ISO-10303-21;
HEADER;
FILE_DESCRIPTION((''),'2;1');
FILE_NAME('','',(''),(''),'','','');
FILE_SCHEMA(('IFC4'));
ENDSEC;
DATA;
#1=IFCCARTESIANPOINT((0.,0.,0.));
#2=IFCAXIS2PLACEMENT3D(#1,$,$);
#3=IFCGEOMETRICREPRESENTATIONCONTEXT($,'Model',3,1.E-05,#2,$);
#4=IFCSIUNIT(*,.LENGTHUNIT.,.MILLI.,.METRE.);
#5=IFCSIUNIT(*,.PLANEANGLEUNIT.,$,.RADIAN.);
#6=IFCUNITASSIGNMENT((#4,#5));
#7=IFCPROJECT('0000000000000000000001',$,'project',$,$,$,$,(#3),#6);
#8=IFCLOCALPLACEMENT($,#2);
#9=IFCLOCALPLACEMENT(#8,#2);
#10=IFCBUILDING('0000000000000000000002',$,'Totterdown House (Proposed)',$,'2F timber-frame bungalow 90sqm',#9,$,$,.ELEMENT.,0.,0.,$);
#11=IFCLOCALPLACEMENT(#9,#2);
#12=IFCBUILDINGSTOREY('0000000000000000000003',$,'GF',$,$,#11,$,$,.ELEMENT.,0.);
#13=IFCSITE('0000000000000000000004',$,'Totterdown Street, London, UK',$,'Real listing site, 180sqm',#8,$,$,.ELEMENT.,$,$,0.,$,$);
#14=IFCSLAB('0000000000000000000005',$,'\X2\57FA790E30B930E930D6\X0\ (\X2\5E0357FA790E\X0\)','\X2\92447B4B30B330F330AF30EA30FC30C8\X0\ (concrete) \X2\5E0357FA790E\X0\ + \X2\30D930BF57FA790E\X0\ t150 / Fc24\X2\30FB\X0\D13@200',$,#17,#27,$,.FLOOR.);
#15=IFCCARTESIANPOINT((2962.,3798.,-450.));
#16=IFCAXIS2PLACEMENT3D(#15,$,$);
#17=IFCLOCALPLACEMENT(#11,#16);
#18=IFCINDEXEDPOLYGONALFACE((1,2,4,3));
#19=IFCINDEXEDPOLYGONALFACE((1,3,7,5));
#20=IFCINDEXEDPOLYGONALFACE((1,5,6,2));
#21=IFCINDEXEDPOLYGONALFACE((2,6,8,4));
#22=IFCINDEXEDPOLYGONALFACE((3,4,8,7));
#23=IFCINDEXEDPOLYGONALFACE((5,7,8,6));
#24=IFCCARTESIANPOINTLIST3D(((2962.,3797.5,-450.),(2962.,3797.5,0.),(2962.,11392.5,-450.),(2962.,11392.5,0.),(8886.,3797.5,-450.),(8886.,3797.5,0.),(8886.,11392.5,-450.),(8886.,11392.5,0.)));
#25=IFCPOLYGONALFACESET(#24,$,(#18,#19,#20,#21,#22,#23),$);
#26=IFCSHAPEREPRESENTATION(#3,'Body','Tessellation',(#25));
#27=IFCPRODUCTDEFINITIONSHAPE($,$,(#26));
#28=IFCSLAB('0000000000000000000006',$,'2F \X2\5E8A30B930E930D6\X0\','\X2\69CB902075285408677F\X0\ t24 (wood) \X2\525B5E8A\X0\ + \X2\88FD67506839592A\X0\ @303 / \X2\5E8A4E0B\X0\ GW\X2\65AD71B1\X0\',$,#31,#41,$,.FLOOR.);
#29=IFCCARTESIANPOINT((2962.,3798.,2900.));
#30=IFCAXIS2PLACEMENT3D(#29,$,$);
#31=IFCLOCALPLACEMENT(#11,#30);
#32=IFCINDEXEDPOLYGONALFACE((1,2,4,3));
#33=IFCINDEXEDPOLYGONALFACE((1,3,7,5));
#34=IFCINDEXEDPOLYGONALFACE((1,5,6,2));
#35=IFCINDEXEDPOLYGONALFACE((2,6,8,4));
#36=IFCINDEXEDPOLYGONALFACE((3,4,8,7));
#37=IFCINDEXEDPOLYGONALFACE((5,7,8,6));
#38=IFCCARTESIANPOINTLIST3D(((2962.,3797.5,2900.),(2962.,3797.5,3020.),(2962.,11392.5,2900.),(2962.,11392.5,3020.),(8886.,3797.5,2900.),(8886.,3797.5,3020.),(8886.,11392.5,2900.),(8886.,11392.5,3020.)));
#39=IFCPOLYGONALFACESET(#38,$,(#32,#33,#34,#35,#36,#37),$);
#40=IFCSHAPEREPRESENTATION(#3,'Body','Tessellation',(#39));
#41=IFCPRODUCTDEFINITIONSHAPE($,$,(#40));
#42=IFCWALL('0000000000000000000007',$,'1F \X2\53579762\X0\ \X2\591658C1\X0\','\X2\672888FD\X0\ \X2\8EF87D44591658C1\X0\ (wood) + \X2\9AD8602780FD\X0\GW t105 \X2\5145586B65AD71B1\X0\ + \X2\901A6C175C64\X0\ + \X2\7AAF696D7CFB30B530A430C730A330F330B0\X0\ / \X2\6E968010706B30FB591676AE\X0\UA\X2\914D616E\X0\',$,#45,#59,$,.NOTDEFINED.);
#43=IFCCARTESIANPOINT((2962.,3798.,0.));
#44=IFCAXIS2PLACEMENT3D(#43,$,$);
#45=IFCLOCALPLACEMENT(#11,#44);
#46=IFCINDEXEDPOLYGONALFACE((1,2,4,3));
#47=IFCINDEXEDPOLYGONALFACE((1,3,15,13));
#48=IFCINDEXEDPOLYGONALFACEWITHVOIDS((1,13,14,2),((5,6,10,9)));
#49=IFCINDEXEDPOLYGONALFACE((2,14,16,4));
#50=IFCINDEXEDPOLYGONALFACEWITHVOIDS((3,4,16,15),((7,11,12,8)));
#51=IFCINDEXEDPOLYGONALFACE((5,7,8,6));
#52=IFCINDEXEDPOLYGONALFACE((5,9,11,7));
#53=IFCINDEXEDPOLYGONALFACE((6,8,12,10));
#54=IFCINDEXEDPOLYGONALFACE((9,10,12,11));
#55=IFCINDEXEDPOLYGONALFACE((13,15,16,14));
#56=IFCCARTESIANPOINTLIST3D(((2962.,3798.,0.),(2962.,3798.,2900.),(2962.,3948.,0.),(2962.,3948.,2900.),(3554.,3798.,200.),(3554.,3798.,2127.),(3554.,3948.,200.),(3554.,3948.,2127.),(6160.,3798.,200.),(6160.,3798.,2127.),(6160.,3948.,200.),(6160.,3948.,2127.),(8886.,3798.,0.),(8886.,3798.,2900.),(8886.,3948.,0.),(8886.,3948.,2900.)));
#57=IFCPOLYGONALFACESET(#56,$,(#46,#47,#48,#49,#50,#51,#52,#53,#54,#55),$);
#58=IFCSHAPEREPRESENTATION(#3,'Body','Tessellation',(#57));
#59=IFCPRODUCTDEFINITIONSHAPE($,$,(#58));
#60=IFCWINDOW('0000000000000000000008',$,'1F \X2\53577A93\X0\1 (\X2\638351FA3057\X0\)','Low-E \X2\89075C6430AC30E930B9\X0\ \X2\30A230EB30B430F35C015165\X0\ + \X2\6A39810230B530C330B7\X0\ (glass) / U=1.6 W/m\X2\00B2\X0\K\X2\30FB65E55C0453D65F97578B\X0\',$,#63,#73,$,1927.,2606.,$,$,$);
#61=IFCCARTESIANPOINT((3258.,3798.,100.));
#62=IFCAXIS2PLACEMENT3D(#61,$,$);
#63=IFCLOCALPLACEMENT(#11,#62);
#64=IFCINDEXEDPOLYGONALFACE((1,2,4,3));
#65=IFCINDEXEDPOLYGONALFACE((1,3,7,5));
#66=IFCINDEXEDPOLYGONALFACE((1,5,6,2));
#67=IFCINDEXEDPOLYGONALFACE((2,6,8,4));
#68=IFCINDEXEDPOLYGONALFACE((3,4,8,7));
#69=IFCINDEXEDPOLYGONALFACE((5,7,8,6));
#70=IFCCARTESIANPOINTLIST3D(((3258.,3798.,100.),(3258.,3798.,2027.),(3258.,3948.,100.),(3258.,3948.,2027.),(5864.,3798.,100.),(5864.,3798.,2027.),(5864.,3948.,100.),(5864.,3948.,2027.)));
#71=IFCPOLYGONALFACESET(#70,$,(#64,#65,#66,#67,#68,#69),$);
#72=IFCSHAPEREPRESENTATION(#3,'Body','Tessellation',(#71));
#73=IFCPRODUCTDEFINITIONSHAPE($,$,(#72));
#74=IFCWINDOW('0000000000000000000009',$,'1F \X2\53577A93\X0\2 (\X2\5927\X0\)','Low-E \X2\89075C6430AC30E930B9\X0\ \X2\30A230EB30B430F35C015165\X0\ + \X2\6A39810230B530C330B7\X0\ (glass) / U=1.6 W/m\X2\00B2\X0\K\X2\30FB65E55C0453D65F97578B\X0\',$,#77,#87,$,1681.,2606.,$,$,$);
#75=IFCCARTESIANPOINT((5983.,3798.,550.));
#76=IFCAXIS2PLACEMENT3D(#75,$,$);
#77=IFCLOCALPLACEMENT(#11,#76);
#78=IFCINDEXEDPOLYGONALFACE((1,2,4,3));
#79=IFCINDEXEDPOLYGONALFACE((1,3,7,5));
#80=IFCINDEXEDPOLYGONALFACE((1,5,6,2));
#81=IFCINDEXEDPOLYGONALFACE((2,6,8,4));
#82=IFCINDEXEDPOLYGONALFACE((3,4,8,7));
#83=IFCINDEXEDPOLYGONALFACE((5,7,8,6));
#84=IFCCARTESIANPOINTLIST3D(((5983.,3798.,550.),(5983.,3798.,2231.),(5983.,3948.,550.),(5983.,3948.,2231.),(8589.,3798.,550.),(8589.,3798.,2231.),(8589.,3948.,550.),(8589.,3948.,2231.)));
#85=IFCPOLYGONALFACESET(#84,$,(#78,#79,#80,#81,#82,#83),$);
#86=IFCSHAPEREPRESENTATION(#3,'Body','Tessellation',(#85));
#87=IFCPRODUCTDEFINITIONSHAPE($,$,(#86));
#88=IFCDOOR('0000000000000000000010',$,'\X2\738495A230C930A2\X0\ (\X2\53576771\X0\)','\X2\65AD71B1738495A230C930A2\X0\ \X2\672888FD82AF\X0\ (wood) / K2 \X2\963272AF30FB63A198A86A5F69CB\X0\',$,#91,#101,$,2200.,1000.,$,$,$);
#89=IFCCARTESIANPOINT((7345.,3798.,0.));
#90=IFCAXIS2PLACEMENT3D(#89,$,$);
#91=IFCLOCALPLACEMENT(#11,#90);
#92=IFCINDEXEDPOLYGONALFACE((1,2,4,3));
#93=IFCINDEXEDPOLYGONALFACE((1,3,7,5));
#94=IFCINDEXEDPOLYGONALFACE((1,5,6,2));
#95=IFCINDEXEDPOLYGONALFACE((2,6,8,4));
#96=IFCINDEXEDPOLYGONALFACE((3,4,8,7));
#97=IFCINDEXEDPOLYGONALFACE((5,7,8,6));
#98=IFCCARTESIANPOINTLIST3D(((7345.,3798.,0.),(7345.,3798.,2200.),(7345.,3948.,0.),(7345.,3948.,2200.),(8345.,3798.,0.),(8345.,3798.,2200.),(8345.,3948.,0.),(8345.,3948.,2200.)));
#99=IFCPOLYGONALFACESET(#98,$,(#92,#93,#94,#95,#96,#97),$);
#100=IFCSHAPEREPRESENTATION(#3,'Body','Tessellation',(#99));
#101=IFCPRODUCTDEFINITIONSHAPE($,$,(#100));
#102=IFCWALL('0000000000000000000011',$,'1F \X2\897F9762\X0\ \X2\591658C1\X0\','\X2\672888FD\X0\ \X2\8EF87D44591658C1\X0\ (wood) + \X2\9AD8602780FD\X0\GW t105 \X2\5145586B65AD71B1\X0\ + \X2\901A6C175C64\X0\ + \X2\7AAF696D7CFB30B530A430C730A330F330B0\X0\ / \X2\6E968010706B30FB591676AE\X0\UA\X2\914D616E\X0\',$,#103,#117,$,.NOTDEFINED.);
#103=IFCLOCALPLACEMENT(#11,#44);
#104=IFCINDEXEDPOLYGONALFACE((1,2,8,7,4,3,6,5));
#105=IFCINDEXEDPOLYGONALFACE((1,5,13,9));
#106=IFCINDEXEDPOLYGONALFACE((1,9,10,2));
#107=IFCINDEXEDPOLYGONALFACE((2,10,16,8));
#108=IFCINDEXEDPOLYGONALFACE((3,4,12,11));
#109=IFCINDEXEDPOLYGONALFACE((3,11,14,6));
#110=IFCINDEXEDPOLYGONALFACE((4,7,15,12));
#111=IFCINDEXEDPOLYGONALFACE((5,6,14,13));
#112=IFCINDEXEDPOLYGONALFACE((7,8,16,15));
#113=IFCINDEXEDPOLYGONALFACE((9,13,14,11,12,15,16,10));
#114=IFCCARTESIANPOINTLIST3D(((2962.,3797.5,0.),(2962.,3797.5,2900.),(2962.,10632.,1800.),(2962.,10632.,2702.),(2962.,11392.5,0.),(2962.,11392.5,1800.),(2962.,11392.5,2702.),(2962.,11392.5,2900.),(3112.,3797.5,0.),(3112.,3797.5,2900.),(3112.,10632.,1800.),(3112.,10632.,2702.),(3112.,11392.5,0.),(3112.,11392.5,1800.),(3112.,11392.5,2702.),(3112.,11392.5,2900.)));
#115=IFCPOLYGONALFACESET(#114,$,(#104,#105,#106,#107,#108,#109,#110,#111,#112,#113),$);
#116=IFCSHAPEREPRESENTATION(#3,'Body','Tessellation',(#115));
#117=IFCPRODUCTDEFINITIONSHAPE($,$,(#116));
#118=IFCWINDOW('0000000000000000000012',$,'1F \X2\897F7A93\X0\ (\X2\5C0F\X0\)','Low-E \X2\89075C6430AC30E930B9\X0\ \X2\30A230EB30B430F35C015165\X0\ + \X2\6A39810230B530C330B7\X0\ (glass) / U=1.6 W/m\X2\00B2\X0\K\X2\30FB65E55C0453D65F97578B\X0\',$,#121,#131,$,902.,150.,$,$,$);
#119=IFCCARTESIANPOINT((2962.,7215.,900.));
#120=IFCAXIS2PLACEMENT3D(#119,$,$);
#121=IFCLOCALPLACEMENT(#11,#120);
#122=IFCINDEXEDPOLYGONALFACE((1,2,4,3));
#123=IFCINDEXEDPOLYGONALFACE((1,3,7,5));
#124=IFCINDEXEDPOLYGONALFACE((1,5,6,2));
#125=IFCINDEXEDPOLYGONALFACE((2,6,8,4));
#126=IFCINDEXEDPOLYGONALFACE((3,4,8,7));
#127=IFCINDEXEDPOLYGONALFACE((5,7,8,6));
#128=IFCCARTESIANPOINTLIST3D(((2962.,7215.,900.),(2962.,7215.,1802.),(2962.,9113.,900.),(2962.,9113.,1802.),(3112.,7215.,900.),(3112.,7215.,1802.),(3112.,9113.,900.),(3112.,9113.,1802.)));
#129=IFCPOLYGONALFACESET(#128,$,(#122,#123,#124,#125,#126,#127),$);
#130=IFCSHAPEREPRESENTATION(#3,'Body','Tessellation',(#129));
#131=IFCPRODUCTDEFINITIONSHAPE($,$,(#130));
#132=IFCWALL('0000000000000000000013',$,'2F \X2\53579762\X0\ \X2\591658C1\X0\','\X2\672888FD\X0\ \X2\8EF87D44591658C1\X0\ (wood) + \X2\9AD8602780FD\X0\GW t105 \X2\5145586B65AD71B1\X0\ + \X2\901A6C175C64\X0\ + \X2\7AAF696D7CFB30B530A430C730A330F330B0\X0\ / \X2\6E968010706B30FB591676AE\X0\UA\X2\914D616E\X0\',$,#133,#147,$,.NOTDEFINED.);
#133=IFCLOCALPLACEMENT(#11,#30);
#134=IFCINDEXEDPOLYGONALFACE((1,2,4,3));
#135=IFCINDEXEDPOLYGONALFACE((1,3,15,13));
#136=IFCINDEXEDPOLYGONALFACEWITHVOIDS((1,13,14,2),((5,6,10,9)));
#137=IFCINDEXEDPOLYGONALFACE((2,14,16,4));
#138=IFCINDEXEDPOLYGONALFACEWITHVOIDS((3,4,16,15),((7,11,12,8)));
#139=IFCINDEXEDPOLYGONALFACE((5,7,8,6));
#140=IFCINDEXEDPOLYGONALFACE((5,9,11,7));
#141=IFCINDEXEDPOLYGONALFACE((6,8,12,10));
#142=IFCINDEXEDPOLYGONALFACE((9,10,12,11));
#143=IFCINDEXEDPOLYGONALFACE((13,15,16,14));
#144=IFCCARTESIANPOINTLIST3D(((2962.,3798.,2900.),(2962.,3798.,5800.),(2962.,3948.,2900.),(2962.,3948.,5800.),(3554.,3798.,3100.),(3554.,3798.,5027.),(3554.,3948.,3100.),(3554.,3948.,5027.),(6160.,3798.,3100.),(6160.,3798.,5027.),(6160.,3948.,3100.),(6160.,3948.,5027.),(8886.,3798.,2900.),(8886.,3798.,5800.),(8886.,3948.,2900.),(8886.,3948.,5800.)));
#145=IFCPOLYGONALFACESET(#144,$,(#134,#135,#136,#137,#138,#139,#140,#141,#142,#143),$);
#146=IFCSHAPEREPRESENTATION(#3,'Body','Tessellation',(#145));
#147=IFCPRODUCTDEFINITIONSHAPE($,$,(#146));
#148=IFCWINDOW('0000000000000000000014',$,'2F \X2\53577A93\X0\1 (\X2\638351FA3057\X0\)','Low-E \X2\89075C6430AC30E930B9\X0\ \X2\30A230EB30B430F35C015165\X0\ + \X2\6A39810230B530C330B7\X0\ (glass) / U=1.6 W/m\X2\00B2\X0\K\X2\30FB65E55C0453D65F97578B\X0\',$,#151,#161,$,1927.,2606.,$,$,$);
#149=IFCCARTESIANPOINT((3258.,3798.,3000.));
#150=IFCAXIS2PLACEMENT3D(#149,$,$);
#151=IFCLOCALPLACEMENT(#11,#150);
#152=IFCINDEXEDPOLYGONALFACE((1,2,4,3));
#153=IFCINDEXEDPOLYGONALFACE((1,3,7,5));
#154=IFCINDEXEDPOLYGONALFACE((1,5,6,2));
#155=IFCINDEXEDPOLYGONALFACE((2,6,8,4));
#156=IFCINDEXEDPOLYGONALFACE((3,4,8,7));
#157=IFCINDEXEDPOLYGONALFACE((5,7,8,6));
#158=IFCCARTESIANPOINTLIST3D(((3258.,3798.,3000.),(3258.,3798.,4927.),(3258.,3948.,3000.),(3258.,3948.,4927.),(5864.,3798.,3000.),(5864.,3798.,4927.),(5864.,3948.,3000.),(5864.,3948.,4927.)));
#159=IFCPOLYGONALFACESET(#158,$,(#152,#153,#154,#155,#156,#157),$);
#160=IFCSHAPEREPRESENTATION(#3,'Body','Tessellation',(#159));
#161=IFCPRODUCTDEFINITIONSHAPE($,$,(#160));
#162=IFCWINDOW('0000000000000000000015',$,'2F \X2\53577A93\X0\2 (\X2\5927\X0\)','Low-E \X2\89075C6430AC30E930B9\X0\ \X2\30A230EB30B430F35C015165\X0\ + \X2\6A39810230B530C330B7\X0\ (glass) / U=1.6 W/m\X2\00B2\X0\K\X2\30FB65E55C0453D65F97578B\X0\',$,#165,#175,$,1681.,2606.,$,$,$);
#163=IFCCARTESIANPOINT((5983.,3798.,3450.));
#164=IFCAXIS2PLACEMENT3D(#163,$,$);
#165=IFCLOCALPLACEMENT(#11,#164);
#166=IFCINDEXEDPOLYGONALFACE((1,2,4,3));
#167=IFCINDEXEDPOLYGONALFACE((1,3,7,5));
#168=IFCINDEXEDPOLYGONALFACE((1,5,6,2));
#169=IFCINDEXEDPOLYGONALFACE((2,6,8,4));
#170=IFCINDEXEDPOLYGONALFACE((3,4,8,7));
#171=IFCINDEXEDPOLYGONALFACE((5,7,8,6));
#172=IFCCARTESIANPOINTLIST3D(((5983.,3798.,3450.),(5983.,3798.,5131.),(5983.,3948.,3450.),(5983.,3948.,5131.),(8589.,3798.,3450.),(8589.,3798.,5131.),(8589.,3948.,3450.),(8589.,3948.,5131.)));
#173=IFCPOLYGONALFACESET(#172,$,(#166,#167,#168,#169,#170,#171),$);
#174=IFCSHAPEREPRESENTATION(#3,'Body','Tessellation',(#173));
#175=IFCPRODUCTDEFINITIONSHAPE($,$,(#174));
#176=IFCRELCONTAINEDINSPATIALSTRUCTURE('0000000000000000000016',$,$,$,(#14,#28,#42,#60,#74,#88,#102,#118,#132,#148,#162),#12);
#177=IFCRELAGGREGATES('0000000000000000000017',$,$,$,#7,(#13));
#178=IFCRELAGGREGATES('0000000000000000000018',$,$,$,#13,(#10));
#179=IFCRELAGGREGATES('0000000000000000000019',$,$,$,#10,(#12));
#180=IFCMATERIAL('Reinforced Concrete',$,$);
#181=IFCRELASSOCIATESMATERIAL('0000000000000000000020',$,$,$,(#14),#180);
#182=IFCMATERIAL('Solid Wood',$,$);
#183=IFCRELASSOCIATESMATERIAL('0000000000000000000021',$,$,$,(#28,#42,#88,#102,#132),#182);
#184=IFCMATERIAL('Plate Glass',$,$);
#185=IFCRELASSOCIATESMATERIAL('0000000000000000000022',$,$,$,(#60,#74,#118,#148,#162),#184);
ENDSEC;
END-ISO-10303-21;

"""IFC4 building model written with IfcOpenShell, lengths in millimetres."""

from ifc_helpers import new_model, si_unit, frame, frame_2d, origin, place, context, project, spatial, rectangle, extrude, material, element, fill, save


model = new_model("IFC4")

# Units and contexts
model_context = context("Model", 3, precision=1e-05, world=origin())
ifc_project = project(units=[si_unit("LENGTHUNIT", "METRE", prefix="MILLI"), si_unit("PLANEANGLEUNIT", "RADIAN")], contexts=[model_context])

# Site, building, storey
site_placement = place(None, origin())
site = spatial("IfcSite", under=ifc_project, at=site_placement, Name="Totterdown Street, London, UK", ObjectType="Real listing site, 180sqm", CompositionType="ELEMENT", RefElevation=0.0)
building_placement = place(site_placement, origin())
building = spatial("IfcBuilding", under=site, at=building_placement, Name="Totterdown House (Proposed)", ObjectType="2F timber-frame bungalow 90sqm", CompositionType="ELEMENT", ElevationOfRefHeight=0.0, ElevationOfTerrain=0.0)
storey_placement = place(building_placement, origin())
storey = spatial("IfcBuildingStorey", under=building, at=storey_placement, Name="GF", CompositionType="ELEMENT", Elevation=0.0)

# Slabs
ifc_material_1 = material(Name="Reinforced Concrete")
slab_1_placement = place(storey_placement, frame((2962.0, 3798.0, -450.0)))
element("IfcSlab", 1, at=slab_1_placement, inside=storey, material=ifc_material_1, Name="基礎スラブ (布基礎)", Description="鉄筋コンクリート (concrete) 布基礎 + ベタ基礎 t150 / Fc24・D13@200", PredefinedType="FLOOR", context=model_context, shape_type="SweptSolid", body=[
    extrude(rectangle(XDim=5924.0, YDim=7595.0, at=frame_2d((2962.0, 3797.0))), frame((2962.0, 3798.0, -450.0)), (0.0, 0.0, 1.0), 450.0),
])
ifc_material_2 = material(Name="Solid Wood")
slab_2_placement = place(storey_placement, frame((2962.0, 3798.0, 2900.0)))
element("IfcSlab", 2, at=slab_2_placement, inside=storey, material=ifc_material_2, Name="2F 床スラブ", Description="構造用合板 t24 (wood) 剛床 + 製材根太 @303 / 床下 GW断熱", PredefinedType="FLOOR", context=model_context, shape_type="SweptSolid", body=[
    extrude(rectangle(XDim=5924.0, YDim=7595.0, at=frame_2d((2962.0, 3797.0))), frame((2962.0, 3798.0, 2900.0)), (0.0, 0.0, 1.0), 120.0),
])

# Wall, openings, windows, door
wall_1_placement = place(storey_placement, frame((2962.0, 3798.0, 0.0)))
wall_1 = element("IfcWall", 3, at=wall_1_placement, inside=storey, material=ifc_material_2, Name="1F 南面 外壁", Description="木製 軸組外壁 (wood) + 高性能GW t105 充填断熱 + 通気層 + 窯業系サイディング / 準耐火・外皮UA配慮", PredefinedType="NOTDEFINED", context=model_context, shape_type="SweptSolid", body=[
    extrude(rectangle(XDim=5924.0, YDim=150.0, at=frame_2d((2962.0, 75.0))), frame((2962.0, 3798.0, 0.0)), (0.0, 0.0, 1.0), 2900.0),
])
opening_1_placement = place(storey_placement, frame((3258.0, 3798.0, 100.0)))
opening_1 = element("IfcOpeningElement", 4, at=opening_1_placement, cuts=wall_1, PredefinedType="NOTDEFINED", context=model_context, shape_type="SweptSolid", body=[
    extrude(rectangle(XDim=2606.0, YDim=150.0, at=frame_2d((1303.0, 75.0))), frame((3258.0, 3798.0, 100.0)), (0.0, 0.0, 1.0), 1927.0),
])
opening_2_placement = place(storey_placement, frame((5983.0, 3798.0, 550.0)))
opening_2 = element("IfcOpeningElement", 5, at=opening_2_placement, cuts=wall_1, PredefinedType="NOTDEFINED", context=model_context, shape_type="SweptSolid", body=[
    extrude(rectangle(XDim=2606.0, YDim=150.0, at=frame_2d((1303.0, 75.0))), frame((5983.0, 3798.0, 550.0)), (0.0, 0.0, 1.0), 1681.0),
])
opening_3_placement = place(storey_placement, frame((7345.0, 3798.0, 0.0)))
opening_3 = element("IfcOpeningElement", 6, at=opening_3_placement, cuts=wall_1, PredefinedType="NOTDEFINED", context=model_context, shape_type="SweptSolid", body=[
    extrude(rectangle(XDim=1000.0, YDim=150.0, at=frame_2d((500.0, 75.0))), frame((7345.0, 3798.0, 0.0)), (0.0, 0.0, 1.0), 2200.0),
])
ifc_material_3 = material(Name="Plate Glass")
window_1_placement = place(storey_placement, frame((3258.0, 3798.0, 100.0)))
window_1 = element("IfcWindow", 7, at=window_1_placement, inside=storey, material=ifc_material_3, Name="1F 南窓1 (掃出し)", Description="Low-E 複層ガラス アルゴン封入 + 樹脂サッシ (glass) / U=1.6 W/m²K・日射取得型", OverallHeight=1927.0, OverallWidth=2606.0, context=model_context, shape_type="SweptSolid", body=[
    extrude(rectangle(XDim=2606.0, YDim=150.0, at=frame_2d((1303.0, 75.0))), frame((3258.0, 3798.0, 100.0)), (0.0, 0.0, 1.0), 1927.0),
])
fill(opening_1, window_1)
window_2_placement = place(storey_placement, frame((5983.0, 3798.0, 550.0)))
window_2 = element("IfcWindow", 8, at=window_2_placement, inside=storey, material=ifc_material_3, Name="1F 南窓2 (大)", Description="Low-E 複層ガラス アルゴン封入 + 樹脂サッシ (glass) / U=1.6 W/m²K・日射取得型", OverallHeight=1681.0, OverallWidth=2606.0, context=model_context, shape_type="SweptSolid", body=[
    extrude(rectangle(XDim=2606.0, YDim=150.0, at=frame_2d((1303.0, 75.0))), frame((5983.0, 3798.0, 550.0)), (0.0, 0.0, 1.0), 1681.0),
])
fill(opening_2, window_2)
door_placement = place(storey_placement, frame((7345.0, 3798.0, 0.0)))
door = element("IfcDoor", 9, at=door_placement, inside=storey, material=ifc_material_2, Name="玄関ドア (南東)", Description="断熱玄関ドア 木製芯 (wood) / K2 防犯・採風機構", OverallHeight=2200.0, OverallWidth=1000.0, context=model_context, shape_type="SweptSolid", body=[
    extrude(rectangle(XDim=1000.0, YDim=150.0, at=frame_2d((500.0, 75.0))), frame((7345.0, 3798.0, 0.0)), (0.0, 0.0, 1.0), 2200.0),
])
fill(opening_3, door)

# Wall, opening, window
wall_2_placement = place(storey_placement, frame((2962.0, 3798.0, 0.0)))
wall_2 = element("IfcWall", 10, at=wall_2_placement, inside=storey, material=ifc_material_2, Name="1F 西面 外壁", Description="木製 軸組外壁 (wood) + 高性能GW t105 充填断熱 + 通気層 + 窯業系サイディング / 準耐火・外皮UA配慮", PredefinedType="NOTDEFINED", context=model_context, shape_type="SweptSolid", body=[
    extrude(rectangle(XDim=150.0, YDim=7595.0, at=frame_2d((75.0, 3797.0))), frame((2962.0, 3798.0, 0.0)), (0.0, 0.0, 1.0), 2900.0),
])
opening_4_placement = place(storey_placement, frame((2962.0, 7215.0, 900.0)))
opening_4 = element("IfcOpeningElement", 11, at=opening_4_placement, cuts=wall_2, PredefinedType="NOTDEFINED", context=model_context, shape_type="SweptSolid", body=[
    extrude(rectangle(XDim=150.0, YDim=1898.0, at=frame_2d((75.0, 949.0))), frame((2962.0, 7215.0, 900.0)), (0.0, 0.0, 1.0), 902.0),
])
window_3_placement = place(storey_placement, frame((2962.0, 7215.0, 900.0)))
window_3 = element("IfcWindow", 12, at=window_3_placement, inside=storey, material=ifc_material_3, Name="1F 西窓 (小)", Description="Low-E 複層ガラス アルゴン封入 + 樹脂サッシ (glass) / U=1.6 W/m²K・日射取得型", OverallHeight=902.0, OverallWidth=150.0, context=model_context, shape_type="SweptSolid", body=[
    extrude(rectangle(XDim=150.0, YDim=1898.0, at=frame_2d((75.0, 949.0))), frame((2962.0, 7215.0, 900.0)), (0.0, 0.0, 1.0), 902.0),
])
fill(opening_4, window_3)

# Wall, openings, windows
wall_3_placement = place(storey_placement, frame((2962.0, 3798.0, 2900.0)))
wall_3 = element("IfcWall", 13, at=wall_3_placement, inside=storey, material=ifc_material_2, Name="2F 南面 外壁", Description="木製 軸組外壁 (wood) + 高性能GW t105 充填断熱 + 通気層 + 窯業系サイディング / 準耐火・外皮UA配慮", PredefinedType="NOTDEFINED", context=model_context, shape_type="SweptSolid", body=[
    extrude(rectangle(XDim=5924.0, YDim=150.0, at=frame_2d((2962.0, 75.0))), frame((2962.0, 3798.0, 2900.0)), (0.0, 0.0, 1.0), 2900.0),
])
opening_5_placement = place(storey_placement, frame((3258.0, 3798.0, 3000.0)))
opening_5 = element("IfcOpeningElement", 14, at=opening_5_placement, cuts=wall_3, PredefinedType="NOTDEFINED", context=model_context, shape_type="SweptSolid", body=[
    extrude(rectangle(XDim=2606.0, YDim=150.0, at=frame_2d((1303.0, 75.0))), frame((3258.0, 3798.0, 3000.0)), (0.0, 0.0, 1.0), 1927.0),
])
opening_6_placement = place(storey_placement, frame((5983.0, 3798.0, 3450.0)))
opening_6 = element("IfcOpeningElement", 15, at=opening_6_placement, cuts=wall_3, PredefinedType="NOTDEFINED", context=model_context, shape_type="SweptSolid", body=[
    extrude(rectangle(XDim=2606.0, YDim=150.0, at=frame_2d((1303.0, 75.0))), frame((5983.0, 3798.0, 3450.0)), (0.0, 0.0, 1.0), 1681.0),
])
window_4_placement = place(storey_placement, frame((3258.0, 3798.0, 3000.0)))
window_4 = element("IfcWindow", 16, at=window_4_placement, inside=storey, material=ifc_material_3, Name="2F 南窓1 (掃出し)", Description="Low-E 複層ガラス アルゴン封入 + 樹脂サッシ (glass) / U=1.6 W/m²K・日射取得型", OverallHeight=1927.0, OverallWidth=2606.0, context=model_context, shape_type="SweptSolid", body=[
    extrude(rectangle(XDim=2606.0, YDim=150.0, at=frame_2d((1303.0, 75.0))), frame((3258.0, 3798.0, 3000.0)), (0.0, 0.0, 1.0), 1927.0),
])
fill(opening_5, window_4)
window_5_placement = place(storey_placement, frame((5983.0, 3798.0, 3450.0)))
window_5 = element("IfcWindow", 17, at=window_5_placement, inside=storey, material=ifc_material_3, Name="2F 南窓2 (大)", Description="Low-E 複層ガラス アルゴン封入 + 樹脂サッシ (glass) / U=1.6 W/m²K・日射取得型", OverallHeight=1681.0, OverallWidth=2606.0, context=model_context, shape_type="SweptSolid", body=[
    extrude(rectangle(XDim=2606.0, YDim=150.0, at=frame_2d((1303.0, 75.0))), frame((5983.0, 3798.0, 3450.0)), (0.0, 0.0, 1.0), 1681.0),
])
fill(opening_6, window_5)

save(model, "model.ifc")
